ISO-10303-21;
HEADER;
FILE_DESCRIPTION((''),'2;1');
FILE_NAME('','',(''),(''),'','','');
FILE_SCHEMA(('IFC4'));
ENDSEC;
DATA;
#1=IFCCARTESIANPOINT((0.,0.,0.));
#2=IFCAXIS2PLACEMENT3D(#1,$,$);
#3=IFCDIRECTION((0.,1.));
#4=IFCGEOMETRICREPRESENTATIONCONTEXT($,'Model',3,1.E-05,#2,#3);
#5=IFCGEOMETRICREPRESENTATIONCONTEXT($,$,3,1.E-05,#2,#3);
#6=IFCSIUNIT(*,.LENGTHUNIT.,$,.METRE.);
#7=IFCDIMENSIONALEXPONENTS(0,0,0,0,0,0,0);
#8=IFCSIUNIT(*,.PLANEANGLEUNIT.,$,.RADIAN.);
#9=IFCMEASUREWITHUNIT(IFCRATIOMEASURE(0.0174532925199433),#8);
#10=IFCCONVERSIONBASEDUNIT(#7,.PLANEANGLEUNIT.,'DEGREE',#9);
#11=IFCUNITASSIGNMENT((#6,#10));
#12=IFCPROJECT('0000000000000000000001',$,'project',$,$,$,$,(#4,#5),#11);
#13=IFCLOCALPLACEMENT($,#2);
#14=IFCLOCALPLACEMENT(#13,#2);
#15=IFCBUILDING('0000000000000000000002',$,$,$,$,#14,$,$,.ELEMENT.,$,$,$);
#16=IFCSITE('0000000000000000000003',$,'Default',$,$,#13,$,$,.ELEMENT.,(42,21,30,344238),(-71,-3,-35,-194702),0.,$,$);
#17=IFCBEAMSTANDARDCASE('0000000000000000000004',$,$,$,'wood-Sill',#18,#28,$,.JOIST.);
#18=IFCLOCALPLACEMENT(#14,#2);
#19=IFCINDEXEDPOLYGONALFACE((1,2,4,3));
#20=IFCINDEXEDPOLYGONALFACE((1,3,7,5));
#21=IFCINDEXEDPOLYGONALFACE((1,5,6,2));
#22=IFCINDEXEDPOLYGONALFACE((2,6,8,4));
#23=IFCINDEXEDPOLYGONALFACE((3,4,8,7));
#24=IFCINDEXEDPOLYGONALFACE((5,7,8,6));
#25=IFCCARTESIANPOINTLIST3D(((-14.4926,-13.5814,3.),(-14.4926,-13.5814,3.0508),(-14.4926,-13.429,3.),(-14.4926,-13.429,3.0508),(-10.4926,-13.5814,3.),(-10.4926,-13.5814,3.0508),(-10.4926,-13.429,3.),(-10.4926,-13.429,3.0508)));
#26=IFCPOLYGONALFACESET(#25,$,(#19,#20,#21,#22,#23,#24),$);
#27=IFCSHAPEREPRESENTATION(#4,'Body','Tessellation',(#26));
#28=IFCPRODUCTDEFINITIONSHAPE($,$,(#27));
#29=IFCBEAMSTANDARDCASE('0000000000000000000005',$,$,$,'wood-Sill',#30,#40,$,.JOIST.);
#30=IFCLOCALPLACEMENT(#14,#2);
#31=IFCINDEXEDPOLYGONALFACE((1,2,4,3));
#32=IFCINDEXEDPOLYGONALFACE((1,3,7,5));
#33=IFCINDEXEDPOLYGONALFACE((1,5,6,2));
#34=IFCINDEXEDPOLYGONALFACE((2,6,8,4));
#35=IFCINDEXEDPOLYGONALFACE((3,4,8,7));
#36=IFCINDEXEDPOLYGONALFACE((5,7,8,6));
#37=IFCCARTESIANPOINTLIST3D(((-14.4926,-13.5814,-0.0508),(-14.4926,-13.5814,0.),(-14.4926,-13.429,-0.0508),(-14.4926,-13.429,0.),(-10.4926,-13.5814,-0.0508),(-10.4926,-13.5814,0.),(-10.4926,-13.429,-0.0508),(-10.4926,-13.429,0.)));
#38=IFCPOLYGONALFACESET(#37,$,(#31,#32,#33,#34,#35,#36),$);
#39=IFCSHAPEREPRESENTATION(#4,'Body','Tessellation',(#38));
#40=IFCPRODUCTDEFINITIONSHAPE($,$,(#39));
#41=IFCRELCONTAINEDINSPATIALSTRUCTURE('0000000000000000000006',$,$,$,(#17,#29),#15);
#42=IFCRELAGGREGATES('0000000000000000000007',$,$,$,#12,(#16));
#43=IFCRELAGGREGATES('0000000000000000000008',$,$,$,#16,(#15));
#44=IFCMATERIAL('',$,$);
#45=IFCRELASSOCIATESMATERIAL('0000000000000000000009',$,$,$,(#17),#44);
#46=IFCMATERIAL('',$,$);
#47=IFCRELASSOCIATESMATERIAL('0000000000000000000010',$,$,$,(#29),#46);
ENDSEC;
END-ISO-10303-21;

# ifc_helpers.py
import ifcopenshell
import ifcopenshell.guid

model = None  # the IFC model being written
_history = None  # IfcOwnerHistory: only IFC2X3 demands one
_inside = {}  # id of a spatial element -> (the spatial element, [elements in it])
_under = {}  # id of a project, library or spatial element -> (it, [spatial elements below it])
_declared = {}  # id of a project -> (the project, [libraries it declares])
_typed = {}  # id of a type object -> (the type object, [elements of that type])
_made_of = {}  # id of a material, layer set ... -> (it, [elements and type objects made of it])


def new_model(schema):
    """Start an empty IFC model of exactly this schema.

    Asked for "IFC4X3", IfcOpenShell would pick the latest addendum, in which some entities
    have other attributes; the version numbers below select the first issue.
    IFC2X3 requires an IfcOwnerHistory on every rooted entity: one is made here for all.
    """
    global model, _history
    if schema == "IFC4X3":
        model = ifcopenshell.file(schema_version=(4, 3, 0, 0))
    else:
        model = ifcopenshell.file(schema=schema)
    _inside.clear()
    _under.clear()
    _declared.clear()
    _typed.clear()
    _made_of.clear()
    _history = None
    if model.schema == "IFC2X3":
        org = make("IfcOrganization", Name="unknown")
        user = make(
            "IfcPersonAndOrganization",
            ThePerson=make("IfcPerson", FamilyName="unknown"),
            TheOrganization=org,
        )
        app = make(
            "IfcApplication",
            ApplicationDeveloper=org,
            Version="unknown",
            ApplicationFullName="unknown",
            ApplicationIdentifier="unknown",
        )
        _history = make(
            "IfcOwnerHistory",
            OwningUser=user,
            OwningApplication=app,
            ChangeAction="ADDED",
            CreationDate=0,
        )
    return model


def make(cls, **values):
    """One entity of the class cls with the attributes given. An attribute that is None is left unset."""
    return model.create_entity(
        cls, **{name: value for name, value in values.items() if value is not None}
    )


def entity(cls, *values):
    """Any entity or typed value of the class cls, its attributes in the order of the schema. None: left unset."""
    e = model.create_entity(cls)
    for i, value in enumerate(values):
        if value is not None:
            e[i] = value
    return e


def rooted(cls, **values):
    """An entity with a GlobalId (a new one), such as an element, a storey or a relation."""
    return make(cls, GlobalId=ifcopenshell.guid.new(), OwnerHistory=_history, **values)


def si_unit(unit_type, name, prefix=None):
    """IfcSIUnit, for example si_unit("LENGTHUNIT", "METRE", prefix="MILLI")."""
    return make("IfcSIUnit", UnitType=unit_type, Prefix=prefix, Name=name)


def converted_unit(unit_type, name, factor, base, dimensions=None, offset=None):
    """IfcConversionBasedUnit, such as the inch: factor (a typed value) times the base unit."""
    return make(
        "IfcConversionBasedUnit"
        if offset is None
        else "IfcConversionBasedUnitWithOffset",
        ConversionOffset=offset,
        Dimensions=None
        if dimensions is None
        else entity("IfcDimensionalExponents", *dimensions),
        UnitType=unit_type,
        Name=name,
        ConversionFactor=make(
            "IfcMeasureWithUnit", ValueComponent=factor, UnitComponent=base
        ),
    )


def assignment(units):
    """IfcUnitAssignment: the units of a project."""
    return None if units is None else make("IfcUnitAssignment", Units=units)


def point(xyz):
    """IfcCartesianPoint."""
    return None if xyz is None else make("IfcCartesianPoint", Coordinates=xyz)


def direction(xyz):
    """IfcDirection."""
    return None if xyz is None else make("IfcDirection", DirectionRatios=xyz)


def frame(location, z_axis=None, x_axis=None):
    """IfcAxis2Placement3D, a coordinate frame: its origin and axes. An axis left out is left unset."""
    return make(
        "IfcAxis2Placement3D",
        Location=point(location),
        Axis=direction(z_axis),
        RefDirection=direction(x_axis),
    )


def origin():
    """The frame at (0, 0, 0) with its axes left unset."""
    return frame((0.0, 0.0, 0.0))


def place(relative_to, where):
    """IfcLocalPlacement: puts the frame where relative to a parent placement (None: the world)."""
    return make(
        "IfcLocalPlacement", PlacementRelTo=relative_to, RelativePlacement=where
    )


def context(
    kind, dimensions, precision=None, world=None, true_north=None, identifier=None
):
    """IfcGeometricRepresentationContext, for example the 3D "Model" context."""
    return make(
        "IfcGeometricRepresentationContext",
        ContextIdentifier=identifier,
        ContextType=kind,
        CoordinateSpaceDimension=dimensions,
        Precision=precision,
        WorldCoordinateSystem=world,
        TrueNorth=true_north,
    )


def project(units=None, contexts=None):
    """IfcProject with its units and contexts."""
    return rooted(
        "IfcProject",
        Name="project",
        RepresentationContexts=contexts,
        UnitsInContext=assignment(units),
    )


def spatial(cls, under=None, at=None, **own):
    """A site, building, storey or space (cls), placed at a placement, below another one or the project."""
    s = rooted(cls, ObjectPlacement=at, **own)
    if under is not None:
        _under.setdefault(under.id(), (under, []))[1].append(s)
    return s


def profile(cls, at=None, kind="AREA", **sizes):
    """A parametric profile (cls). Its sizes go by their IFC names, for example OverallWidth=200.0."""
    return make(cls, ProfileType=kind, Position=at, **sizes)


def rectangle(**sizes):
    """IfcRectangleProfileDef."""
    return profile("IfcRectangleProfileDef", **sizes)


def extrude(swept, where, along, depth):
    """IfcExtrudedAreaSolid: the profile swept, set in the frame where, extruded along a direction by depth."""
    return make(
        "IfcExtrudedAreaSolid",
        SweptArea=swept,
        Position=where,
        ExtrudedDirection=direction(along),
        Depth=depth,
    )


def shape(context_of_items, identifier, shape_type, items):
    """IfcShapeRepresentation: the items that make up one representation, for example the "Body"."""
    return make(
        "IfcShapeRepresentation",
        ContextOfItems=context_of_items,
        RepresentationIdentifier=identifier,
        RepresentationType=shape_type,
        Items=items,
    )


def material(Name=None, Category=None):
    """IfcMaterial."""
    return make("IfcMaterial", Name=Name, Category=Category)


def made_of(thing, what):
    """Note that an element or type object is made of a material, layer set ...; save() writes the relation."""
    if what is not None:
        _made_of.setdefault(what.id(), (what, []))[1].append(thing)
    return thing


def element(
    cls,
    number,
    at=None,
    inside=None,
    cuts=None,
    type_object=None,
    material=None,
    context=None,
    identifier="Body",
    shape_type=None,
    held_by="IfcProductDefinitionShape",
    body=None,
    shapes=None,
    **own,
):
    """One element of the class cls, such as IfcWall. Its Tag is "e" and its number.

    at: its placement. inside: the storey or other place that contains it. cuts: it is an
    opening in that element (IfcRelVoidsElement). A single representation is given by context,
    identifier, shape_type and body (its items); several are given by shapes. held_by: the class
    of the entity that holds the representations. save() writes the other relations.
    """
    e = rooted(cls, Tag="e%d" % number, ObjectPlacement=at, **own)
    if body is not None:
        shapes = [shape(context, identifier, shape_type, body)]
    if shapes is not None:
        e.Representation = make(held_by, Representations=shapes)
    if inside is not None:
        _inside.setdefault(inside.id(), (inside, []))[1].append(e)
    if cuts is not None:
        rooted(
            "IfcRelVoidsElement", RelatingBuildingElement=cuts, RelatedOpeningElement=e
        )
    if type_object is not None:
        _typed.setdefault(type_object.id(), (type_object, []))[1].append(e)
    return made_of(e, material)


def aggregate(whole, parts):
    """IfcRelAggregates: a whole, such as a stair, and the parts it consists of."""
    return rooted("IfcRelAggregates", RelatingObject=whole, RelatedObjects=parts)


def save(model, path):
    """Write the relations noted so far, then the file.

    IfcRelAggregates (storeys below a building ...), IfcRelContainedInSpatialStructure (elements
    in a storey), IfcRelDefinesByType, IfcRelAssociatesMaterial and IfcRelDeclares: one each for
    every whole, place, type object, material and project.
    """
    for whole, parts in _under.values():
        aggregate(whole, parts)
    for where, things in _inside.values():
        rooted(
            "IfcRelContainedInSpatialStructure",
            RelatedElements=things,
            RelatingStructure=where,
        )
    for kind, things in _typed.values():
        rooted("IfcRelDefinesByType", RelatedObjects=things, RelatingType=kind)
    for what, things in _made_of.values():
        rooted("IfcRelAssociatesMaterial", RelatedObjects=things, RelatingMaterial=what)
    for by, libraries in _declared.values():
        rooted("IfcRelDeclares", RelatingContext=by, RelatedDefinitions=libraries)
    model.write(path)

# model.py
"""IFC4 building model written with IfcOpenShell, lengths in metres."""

from ifc_helpers import new_model, entity, si_unit, converted_unit, direction, frame, origin, place, context, project, spatial, rectangle, extrude, material, element, save


model = new_model("IFC4")

# Units and contexts
model_context = context("Model", 3, precision=1e-05, world=origin(), true_north=direction((0.0, 1.0)))
context_of_model = context(None, 3, precision=1e-05, world=origin(), true_north=direction((0.0, 1.0)))
ifc_project = project(units=[si_unit("LENGTHUNIT", "METRE"), converted_unit("PLANEANGLEUNIT", "DEGREE", entity("IfcRatioMeasure", 0.0174532925199433), si_unit("PLANEANGLEUNIT", "RADIAN"), dimensions=[0, 0, 0, 0, 0, 0, 0])], contexts=[model_context, context_of_model])

# Site, building
site_placement = place(None, origin())
site = spatial("IfcSite", under=ifc_project, at=site_placement, Name="Default", CompositionType="ELEMENT", RefLatitude=(42, 21, 30, 344238), RefLongitude=(-71, -3, -35, -194702), RefElevation=0.0)
building_placement = place(site_placement, origin())
building = spatial("IfcBuilding", under=site, at=building_placement, CompositionType="ELEMENT")

# Shared definitions
placement_1 = place(building_placement, origin())
placement_2 = place(placement_1, frame((-12.4926, -15.5052, 0.0), z_axis=(0.0, 0.0, 1.0), x_axis=(0.0, 1.0, 0.0)))

# Beams
ifc_material_1 = material(Name="")
beam_1_placement = place(placement_2, frame((2.0, 0.0, 3.0), z_axis=(0.0, 0.0, 1.0), x_axis=(0.0, 1.0, 0.0)))
element("IfcBeamStandardCase", 1, at=beam_1_placement, inside=building, material=ifc_material_1, ObjectType="wood-Sill", PredefinedType="JOIST", context=model_context, shape_type="SweptSolid", body=[
    extrude(rectangle(XDim=4.0, YDim=0.1524), origin(), (0.0, 0.0, 1.0), 0.0508),
])
ifc_material_2 = material(Name="")
beam_2_placement = place(placement_2, frame((2.0, 0.0, -0.0508), z_axis=(0.0, 0.0, 1.0), x_axis=(0.0, 1.0, 0.0)))
element("IfcBeamStandardCase", 2, at=beam_2_placement, inside=building, material=ifc_material_2, ObjectType="wood-Sill", PredefinedType="JOIST", context=model_context, shape_type="SweptSolid", body=[
    extrude(rectangle(XDim=4.0, YDim=0.1524), origin(), (0.0, 0.0, 1.0), 0.0508),
])

save(model, "model.ifc")
